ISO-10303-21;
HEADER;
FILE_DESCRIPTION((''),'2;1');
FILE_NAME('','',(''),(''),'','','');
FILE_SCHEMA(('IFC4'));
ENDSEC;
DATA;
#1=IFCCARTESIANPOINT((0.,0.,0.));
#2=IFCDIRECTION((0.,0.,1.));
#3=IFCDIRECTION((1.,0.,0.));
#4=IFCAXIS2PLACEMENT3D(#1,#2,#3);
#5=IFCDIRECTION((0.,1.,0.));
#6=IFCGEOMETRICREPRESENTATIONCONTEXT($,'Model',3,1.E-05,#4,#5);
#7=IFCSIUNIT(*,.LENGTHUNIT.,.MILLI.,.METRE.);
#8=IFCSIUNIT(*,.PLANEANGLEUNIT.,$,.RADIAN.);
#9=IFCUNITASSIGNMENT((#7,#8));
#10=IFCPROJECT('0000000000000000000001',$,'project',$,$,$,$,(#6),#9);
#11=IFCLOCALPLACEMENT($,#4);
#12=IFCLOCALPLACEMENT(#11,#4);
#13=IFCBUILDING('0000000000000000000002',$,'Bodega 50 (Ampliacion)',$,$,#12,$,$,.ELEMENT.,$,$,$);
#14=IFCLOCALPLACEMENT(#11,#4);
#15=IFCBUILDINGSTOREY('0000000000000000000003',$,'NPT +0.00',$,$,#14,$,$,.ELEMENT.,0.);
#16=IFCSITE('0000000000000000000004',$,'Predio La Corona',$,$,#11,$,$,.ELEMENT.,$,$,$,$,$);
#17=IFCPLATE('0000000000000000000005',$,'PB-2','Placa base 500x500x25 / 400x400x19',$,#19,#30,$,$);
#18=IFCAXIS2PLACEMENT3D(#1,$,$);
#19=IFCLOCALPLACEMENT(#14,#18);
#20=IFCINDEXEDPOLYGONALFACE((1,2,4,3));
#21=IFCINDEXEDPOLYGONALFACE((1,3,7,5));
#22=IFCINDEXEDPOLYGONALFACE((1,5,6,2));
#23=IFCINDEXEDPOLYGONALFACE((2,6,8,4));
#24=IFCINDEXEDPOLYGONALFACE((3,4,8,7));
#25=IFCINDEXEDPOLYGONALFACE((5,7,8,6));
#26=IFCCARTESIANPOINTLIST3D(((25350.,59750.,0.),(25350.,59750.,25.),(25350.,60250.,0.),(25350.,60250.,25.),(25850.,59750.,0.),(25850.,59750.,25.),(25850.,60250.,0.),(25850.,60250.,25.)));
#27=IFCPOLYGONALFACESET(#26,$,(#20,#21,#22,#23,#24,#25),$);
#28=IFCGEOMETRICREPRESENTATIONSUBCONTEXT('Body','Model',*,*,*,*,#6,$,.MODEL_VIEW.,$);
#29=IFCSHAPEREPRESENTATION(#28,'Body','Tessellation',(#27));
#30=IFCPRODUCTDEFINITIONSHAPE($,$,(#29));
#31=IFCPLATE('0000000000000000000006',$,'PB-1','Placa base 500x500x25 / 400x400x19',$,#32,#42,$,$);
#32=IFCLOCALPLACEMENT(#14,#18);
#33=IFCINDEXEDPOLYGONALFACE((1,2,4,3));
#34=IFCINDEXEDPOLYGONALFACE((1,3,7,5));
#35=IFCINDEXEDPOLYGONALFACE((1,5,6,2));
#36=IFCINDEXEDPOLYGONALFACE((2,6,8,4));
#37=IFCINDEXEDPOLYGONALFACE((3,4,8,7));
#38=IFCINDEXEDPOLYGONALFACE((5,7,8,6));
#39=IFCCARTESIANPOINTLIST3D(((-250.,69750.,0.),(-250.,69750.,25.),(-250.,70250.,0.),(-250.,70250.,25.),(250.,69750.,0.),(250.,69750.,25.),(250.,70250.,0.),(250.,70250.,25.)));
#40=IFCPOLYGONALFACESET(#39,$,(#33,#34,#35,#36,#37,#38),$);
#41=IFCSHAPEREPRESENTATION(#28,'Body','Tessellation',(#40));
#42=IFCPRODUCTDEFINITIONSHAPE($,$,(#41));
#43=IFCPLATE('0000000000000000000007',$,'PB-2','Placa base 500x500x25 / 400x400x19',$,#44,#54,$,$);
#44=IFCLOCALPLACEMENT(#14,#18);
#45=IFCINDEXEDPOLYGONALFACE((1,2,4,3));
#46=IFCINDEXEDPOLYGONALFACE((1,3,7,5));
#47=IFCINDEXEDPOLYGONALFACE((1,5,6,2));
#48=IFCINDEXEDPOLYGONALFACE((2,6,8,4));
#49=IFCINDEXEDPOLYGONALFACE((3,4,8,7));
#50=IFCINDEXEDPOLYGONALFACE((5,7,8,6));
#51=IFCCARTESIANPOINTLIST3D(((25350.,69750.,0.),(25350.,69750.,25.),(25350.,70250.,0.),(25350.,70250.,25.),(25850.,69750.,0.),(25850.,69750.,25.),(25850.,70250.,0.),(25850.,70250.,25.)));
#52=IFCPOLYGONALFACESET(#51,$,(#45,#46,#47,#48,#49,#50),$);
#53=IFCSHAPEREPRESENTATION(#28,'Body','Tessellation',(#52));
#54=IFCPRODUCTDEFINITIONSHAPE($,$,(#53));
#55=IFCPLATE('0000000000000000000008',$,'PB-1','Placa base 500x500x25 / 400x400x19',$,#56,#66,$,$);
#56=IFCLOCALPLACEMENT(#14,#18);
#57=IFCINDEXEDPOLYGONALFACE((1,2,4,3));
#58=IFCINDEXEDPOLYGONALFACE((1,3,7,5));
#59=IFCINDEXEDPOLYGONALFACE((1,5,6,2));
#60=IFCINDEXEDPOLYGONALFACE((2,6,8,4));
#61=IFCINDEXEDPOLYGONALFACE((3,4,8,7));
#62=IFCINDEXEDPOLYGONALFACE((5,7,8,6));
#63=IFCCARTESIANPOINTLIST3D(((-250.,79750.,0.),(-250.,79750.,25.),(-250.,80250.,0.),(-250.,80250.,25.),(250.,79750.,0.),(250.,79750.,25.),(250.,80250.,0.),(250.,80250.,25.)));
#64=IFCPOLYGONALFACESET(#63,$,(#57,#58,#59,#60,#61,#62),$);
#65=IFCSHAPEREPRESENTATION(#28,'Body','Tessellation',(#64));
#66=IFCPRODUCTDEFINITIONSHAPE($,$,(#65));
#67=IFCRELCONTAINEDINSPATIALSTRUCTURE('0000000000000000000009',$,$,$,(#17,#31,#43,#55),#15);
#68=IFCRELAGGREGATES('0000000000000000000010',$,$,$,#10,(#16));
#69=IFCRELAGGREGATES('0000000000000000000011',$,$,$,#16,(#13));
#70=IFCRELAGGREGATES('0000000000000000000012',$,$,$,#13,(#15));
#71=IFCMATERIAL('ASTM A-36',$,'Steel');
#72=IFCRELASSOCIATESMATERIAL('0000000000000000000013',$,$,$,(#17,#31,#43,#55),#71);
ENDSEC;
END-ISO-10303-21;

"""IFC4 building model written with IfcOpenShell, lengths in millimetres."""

from ifc_helpers import new_model, si_unit, direction, frame, origin_with_axes, origin_2d, place, context, subcontext, project, spatial, rectangle, extrude, material, element, save


model = new_model("IFC4")

# Units and contexts
model_context = context("Model", 3, precision=1e-05, world=origin_with_axes(), true_north=direction((0.0, 1.0, 0.0)))
body_context = subcontext(model_context, "Body", "Model", "MODEL_VIEW")
ifc_project = project(units=[si_unit("LENGTHUNIT", "METRE", prefix="MILLI"), si_unit("PLANEANGLEUNIT", "RADIAN")], contexts=[model_context])

# Site, building, storey
site_placement = place(None, origin_with_axes())
site = spatial("IfcSite", under=ifc_project, at=site_placement, Name="Predio La Corona", CompositionType="ELEMENT")
building_placement = place(site_placement, origin_with_axes())
building = spatial("IfcBuilding", under=site, at=building_placement, Name="Bodega 50 (Ampliacion)", CompositionType="ELEMENT")
storey_placement = place(site_placement, origin_with_axes())
storey = spatial("IfcBuildingStorey", under=building, at=storey_placement, Name="NPT +0.00", CompositionType="ELEMENT", Elevation=0.0)

# Shared definitions
ifc_material = material(Name="ASTM A-36", Category="Steel")

# Plates
for number, where, z_axis, x_axis, name in (
    (1, (25600.0, 60000.0, 0.0), (0.0, 0.0, 1.0), (1.0, 0.0, 0.0), "PB-2"),
    (2, (0.0, 70000.0, 0.0), (0.0, 0.0, 1.0), (1.0, 0.0, 0.0), "PB-1"),
    (3, (25600.0, 70000.0, 0.0), (0.0, 0.0, 1.0), (1.0, 0.0, 0.0), "PB-2"),
    (4, (0.0, 80000.0, 0.0), (0.0, 0.0, 1.0), (1.0, 0.0, 0.0), "PB-1"),
):
    element("IfcPlate", number, at=place(storey_placement, frame(where, z_axis=z_axis, x_axis=x_axis)), inside=storey, material=ifc_material, Name=name, Description="Placa base 500x500x25 / 400x400x19", context=body_context, shape_type="SweptSolid", body=[
        extrude(rectangle(XDim=500.0, YDim=500.0, at=origin_2d()), origin_with_axes(), (0.0, 0.0, 1.0), 25.0),
    ])

save(model, "model.ifc")
